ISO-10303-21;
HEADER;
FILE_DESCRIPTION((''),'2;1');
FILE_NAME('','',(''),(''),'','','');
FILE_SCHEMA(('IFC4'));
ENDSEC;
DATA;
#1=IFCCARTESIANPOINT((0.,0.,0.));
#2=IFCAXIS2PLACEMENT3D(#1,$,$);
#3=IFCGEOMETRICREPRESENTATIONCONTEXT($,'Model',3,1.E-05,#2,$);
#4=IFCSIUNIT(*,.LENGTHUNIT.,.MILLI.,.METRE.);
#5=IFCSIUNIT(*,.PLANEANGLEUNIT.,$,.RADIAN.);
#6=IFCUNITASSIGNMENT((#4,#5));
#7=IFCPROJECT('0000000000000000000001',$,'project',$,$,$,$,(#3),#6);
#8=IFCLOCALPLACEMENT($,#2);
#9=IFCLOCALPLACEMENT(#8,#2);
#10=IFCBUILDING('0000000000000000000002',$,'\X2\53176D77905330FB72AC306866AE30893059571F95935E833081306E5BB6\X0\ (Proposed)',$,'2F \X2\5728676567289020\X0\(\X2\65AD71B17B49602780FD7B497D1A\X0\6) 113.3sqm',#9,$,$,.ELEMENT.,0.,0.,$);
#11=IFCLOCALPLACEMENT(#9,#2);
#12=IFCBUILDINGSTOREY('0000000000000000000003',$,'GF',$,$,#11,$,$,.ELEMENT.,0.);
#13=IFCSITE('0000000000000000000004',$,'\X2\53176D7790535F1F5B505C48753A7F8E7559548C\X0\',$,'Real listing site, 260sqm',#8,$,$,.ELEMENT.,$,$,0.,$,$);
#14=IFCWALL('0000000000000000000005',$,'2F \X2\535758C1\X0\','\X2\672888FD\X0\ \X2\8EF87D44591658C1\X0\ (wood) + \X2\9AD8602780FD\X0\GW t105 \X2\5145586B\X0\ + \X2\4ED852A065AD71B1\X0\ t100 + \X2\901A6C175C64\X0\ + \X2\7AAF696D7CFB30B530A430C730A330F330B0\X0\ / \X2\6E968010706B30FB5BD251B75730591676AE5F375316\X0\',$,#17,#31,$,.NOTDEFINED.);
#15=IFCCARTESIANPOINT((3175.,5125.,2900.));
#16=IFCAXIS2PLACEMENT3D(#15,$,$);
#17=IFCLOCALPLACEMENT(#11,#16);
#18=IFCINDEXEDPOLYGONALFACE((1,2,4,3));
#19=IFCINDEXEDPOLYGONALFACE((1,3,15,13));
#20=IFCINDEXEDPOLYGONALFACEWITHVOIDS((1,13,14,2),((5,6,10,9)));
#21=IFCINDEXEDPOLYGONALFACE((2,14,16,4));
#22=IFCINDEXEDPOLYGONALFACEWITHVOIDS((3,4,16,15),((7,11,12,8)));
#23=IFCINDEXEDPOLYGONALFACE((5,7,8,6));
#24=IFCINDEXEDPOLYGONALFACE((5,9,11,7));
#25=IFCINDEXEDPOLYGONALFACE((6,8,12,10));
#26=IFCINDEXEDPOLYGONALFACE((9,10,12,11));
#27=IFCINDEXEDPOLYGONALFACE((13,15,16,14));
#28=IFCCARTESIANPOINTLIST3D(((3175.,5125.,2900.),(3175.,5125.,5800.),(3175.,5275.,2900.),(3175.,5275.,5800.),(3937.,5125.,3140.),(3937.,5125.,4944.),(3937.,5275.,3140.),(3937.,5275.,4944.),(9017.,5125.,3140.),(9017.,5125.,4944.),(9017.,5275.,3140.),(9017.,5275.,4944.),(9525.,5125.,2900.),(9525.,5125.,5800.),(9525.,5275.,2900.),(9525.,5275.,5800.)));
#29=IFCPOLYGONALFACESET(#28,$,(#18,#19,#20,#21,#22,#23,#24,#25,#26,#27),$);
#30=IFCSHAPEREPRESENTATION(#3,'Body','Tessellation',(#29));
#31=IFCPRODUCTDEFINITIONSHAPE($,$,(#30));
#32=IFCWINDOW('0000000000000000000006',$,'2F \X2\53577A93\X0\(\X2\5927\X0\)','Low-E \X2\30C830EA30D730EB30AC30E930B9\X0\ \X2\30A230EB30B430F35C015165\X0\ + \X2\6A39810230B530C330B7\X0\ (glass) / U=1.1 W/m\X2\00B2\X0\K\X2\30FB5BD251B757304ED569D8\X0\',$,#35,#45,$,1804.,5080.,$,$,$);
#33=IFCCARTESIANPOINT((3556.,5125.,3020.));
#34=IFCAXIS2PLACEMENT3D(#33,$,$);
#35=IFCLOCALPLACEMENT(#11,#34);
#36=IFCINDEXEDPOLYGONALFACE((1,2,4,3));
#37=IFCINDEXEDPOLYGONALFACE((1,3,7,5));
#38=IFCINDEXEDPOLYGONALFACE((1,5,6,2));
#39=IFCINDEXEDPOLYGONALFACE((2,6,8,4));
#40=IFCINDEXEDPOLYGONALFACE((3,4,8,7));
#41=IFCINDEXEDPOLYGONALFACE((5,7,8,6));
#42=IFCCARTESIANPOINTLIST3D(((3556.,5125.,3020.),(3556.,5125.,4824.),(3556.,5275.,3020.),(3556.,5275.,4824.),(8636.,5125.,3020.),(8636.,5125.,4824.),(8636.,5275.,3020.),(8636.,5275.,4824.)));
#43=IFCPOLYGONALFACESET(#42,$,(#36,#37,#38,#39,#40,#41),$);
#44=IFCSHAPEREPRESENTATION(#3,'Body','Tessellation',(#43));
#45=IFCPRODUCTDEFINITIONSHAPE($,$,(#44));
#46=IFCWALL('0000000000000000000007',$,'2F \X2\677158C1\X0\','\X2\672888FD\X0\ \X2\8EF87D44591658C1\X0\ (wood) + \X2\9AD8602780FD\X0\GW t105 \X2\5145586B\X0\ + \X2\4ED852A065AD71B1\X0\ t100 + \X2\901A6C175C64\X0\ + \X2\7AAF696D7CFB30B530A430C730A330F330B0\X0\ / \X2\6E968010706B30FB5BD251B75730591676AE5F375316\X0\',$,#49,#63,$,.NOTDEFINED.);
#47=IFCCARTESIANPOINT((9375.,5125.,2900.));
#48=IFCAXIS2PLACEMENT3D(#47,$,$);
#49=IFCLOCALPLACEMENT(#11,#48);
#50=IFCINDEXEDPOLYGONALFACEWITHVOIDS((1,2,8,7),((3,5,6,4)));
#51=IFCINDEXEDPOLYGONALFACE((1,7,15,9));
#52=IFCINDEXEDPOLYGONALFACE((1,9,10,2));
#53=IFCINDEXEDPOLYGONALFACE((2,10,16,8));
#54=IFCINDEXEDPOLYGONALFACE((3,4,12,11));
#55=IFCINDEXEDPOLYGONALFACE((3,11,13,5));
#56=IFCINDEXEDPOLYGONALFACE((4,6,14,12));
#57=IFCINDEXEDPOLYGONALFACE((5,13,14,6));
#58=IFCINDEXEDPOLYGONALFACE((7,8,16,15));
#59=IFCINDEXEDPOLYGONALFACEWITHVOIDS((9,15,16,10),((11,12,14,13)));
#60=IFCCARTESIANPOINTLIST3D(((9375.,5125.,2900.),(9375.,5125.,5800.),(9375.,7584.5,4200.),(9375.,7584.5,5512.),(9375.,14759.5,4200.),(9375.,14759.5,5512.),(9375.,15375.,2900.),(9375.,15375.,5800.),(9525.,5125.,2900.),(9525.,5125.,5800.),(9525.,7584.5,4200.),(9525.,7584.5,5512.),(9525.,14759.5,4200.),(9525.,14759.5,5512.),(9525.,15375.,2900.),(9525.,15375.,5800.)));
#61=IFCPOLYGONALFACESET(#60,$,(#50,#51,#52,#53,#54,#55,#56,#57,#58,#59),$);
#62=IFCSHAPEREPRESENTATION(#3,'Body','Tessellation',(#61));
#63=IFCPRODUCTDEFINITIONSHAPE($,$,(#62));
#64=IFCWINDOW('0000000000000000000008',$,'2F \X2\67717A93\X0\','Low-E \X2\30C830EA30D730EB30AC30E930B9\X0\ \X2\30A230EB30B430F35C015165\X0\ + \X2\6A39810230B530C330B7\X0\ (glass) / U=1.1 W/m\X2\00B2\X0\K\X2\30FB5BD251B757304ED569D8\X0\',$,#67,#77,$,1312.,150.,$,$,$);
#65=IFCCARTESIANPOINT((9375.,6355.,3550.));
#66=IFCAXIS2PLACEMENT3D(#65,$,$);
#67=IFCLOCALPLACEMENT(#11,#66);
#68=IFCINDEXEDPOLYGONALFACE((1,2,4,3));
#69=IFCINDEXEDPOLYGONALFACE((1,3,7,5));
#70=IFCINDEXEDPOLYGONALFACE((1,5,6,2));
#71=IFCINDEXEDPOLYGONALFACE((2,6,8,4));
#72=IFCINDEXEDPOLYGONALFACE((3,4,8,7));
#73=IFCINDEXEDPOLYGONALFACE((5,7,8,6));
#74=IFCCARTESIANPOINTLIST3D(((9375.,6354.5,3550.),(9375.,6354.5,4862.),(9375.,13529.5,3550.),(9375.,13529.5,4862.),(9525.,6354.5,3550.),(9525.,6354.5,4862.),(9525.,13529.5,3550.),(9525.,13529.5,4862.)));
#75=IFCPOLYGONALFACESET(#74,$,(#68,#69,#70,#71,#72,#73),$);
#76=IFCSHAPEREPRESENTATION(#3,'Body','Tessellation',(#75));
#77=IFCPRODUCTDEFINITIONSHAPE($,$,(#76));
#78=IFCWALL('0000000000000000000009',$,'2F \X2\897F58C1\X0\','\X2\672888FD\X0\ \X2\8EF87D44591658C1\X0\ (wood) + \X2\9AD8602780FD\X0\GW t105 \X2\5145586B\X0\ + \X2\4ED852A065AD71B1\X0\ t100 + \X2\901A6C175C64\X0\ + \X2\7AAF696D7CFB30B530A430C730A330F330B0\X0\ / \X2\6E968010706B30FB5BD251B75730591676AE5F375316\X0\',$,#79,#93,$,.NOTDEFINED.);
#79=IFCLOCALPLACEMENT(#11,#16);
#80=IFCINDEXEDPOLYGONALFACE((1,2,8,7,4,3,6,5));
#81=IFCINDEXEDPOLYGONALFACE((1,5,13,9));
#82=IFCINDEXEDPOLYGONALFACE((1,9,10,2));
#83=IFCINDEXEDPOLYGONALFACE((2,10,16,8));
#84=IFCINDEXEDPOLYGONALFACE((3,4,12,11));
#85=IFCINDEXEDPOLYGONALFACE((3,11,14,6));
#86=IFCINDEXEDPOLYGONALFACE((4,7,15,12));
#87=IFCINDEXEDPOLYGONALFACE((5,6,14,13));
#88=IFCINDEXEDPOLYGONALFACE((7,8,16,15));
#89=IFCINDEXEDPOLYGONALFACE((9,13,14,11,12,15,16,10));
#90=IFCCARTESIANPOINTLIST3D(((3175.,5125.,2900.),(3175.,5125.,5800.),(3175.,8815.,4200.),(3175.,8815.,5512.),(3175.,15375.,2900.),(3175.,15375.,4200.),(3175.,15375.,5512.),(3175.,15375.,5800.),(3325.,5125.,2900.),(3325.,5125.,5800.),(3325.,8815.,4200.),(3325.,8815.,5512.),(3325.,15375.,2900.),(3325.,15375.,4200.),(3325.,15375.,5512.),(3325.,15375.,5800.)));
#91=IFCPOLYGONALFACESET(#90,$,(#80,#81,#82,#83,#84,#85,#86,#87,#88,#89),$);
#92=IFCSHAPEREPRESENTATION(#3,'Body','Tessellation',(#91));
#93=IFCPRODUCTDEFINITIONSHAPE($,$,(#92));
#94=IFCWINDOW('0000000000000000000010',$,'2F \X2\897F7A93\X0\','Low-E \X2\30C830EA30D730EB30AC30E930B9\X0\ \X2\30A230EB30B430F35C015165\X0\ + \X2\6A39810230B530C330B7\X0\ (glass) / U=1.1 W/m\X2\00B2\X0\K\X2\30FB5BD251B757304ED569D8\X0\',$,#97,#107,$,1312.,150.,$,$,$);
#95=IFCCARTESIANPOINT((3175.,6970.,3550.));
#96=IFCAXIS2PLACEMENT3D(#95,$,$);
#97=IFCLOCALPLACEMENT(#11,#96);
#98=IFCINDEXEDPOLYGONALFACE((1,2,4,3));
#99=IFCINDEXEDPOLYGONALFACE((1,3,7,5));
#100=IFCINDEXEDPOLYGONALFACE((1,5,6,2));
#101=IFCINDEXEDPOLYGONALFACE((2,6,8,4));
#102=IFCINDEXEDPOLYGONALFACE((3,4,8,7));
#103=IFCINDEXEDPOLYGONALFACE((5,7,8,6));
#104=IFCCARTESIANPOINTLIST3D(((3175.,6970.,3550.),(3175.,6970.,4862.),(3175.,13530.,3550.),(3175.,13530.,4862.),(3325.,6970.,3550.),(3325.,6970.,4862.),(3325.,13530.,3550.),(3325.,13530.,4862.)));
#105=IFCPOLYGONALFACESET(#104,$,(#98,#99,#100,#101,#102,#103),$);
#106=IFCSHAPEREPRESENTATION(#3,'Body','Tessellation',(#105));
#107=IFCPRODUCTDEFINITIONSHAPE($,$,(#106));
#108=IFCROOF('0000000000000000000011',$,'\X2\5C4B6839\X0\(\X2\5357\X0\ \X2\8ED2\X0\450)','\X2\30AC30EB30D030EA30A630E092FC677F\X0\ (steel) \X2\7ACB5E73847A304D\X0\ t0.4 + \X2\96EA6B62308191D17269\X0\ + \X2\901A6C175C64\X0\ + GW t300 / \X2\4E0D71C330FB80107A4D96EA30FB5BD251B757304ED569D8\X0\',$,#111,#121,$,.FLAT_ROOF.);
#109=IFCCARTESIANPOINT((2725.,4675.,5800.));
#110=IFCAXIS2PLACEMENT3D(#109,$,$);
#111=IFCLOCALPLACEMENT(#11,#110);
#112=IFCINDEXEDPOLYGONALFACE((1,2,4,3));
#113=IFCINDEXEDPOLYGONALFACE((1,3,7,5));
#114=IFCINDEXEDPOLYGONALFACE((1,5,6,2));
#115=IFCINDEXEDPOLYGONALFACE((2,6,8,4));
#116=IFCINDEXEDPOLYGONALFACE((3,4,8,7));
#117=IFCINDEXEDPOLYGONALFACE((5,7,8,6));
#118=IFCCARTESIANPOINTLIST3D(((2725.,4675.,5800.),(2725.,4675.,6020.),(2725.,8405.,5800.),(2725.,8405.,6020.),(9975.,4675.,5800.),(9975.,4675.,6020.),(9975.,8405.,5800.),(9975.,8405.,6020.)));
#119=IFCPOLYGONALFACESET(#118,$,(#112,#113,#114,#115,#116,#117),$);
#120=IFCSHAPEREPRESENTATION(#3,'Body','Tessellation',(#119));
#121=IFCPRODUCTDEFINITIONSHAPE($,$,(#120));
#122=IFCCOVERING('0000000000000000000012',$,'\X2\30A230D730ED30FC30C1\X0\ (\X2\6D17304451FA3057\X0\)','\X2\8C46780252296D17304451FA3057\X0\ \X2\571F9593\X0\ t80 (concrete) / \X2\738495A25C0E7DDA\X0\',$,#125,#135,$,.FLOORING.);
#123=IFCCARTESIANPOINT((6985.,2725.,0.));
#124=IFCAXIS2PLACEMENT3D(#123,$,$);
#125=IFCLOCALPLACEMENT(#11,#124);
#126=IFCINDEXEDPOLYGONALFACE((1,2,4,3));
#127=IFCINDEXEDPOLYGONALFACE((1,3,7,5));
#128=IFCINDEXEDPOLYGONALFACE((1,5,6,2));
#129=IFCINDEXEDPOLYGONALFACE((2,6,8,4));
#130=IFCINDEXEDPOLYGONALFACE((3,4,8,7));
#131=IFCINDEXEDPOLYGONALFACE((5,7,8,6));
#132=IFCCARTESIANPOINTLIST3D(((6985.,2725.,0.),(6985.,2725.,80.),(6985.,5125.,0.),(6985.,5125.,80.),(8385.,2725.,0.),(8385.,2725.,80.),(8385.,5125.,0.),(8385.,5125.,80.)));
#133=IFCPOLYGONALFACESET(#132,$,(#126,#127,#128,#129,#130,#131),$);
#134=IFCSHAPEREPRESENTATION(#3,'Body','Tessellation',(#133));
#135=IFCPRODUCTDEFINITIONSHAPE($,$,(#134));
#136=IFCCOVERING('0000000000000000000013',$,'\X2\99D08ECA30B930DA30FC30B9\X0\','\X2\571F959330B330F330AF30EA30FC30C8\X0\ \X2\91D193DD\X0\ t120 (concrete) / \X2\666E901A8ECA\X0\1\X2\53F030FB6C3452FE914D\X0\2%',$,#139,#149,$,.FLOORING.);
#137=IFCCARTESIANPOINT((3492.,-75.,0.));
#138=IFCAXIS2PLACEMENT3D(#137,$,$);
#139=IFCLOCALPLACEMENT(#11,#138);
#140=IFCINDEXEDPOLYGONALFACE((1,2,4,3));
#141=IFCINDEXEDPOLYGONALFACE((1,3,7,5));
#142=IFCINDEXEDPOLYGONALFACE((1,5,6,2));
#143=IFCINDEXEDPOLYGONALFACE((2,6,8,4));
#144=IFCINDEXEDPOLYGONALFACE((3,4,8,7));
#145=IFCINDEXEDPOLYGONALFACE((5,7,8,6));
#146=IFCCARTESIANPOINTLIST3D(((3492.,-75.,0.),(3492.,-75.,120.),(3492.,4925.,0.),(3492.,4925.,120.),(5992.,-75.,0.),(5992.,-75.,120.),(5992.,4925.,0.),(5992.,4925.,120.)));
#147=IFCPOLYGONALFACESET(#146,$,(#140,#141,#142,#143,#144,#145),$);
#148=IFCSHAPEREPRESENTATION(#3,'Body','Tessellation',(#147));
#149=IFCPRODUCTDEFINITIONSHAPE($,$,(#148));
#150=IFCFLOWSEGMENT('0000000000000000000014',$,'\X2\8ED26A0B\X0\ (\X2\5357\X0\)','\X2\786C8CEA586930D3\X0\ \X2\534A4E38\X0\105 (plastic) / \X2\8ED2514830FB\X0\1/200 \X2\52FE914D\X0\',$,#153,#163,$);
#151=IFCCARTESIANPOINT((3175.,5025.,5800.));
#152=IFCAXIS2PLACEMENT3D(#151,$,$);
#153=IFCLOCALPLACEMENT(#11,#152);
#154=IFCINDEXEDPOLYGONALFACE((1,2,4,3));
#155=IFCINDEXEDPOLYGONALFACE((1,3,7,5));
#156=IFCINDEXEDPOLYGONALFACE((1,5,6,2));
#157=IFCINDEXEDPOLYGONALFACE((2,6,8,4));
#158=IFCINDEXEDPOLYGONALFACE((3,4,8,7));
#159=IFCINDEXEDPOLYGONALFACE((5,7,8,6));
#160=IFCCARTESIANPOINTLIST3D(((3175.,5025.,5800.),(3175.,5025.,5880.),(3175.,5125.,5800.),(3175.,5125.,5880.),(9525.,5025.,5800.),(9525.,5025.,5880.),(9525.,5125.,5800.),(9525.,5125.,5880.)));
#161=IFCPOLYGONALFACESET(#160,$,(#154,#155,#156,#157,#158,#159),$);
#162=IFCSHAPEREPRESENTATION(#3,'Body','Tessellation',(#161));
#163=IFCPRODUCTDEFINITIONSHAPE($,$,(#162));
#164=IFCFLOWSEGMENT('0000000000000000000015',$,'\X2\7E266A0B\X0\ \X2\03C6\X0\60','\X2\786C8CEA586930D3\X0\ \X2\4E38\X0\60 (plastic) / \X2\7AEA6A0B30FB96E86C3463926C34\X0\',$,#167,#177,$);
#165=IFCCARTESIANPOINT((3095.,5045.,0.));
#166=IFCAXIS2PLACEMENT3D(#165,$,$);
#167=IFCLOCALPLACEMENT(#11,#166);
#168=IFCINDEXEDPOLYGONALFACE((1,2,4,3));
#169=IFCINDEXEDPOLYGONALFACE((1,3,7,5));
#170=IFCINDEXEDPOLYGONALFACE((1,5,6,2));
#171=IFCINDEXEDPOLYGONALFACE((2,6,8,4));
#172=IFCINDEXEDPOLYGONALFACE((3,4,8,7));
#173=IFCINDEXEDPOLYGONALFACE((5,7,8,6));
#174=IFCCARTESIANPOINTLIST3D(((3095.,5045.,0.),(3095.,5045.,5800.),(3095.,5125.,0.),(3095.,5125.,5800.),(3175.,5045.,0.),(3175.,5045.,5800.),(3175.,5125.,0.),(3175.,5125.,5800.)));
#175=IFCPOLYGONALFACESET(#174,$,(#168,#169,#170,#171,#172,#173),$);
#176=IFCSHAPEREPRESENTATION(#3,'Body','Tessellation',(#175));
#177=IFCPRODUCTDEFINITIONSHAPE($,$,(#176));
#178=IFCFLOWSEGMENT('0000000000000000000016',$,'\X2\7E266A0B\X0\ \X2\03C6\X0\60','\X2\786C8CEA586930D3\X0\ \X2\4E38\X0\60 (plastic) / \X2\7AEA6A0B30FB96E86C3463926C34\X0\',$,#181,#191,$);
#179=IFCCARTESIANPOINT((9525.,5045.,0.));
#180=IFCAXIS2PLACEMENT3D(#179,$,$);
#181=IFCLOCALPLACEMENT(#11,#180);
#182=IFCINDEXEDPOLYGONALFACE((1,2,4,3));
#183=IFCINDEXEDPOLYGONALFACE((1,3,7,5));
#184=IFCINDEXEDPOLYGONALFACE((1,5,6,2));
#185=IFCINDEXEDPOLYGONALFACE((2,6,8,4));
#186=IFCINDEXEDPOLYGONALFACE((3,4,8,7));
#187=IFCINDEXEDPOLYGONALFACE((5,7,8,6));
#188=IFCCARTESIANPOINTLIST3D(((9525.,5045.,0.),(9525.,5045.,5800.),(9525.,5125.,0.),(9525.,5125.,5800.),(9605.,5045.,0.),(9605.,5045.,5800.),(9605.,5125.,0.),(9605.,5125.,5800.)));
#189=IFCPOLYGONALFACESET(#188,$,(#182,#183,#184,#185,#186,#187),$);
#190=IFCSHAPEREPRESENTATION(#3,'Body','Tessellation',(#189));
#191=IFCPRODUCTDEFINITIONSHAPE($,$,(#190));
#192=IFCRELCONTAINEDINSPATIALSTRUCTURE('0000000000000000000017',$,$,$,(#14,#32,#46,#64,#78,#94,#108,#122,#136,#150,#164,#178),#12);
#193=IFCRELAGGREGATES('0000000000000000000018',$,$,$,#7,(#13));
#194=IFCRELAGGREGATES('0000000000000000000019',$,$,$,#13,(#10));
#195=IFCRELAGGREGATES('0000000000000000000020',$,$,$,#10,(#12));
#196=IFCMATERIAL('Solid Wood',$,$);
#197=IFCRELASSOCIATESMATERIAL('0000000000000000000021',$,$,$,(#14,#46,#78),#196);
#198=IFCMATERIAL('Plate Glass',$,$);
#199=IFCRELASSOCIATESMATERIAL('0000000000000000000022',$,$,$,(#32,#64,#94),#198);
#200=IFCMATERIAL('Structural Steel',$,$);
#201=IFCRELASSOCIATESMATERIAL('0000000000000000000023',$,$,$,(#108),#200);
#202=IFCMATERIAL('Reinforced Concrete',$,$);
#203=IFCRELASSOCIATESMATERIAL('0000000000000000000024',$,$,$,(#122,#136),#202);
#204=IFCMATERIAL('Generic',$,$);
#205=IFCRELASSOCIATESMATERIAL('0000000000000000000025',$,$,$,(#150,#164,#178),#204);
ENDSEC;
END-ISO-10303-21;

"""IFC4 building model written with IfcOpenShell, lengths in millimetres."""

from ifc_helpers import new_model, si_unit, frame, frame_2d, origin, place, context, project, spatial, rectangle, extrude, material, element, fill, save


model = new_model("IFC4")

# Units and contexts
model_context = context("Model", 3, precision=1e-05, world=origin())
ifc_project = project(units=[si_unit("LENGTHUNIT", "METRE", prefix="MILLI"), si_unit("PLANEANGLEUNIT", "RADIAN")], contexts=[model_context])

# Site, building, storey
site_placement = place(None, origin())
site = spatial("IfcSite", under=ifc_project, at=site_placement, Name="北海道弟子屈町美留和", ObjectType="Real listing site, 260sqm", CompositionType="ELEMENT", RefElevation=0.0)
building_placement = place(site_placement, origin())
building = spatial("IfcBuilding", under=site, at=building_placement, Name="北海道・犬と暮らす土間広めの家 (Proposed)", ObjectType="2F 在来木造(断熱等性能等級6) 113.3sqm", CompositionType="ELEMENT", ElevationOfRefHeight=0.0, ElevationOfTerrain=0.0)
storey_placement = place(building_placement, origin())
storey = spatial("IfcBuildingStorey", under=building, at=storey_placement, Name="GF", CompositionType="ELEMENT", Elevation=0.0)

# Shared definitions
ifc_material_1 = material(Name="Solid Wood")

# Shared definitions
ifc_material_2 = material(Name="Reinforced Concrete")

# Shared definitions
ifc_material_3 = material(Name="Plate Glass")

# Walls, openings, windows
wall_1_placement = place(storey_placement, frame((3175.0, 5125.0, 2900.0)))
wall_1 = element("IfcWall", 1, at=wall_1_placement, inside=storey, material=ifc_material_1, Name="2F 南壁", Description="木製 軸組外壁 (wood) + 高性能GW t105 充填 + 付加断熱 t100 + 通気層 + 窯業系サイディング / 準耐火・寒冷地外皮強化", PredefinedType="NOTDEFINED", context=model_context, shape_type="SweptSolid", body=[
    extrude(rectangle(XDim=6350.0, YDim=150.0, at=frame_2d((3175.0, 75.0))), frame((3175.0, 5125.0, 2900.0)), (0.0, 0.0, 1.0), 2900.0),
])
opening_1_placement = place(storey_placement, frame((3556.0, 5125.0, 3020.0)))
opening_1 = element("IfcOpeningElement", 2, at=opening_1_placement, cuts=wall_1, PredefinedType="NOTDEFINED", context=model_context, shape_type="SweptSolid", body=[
    extrude(rectangle(XDim=5080.0, YDim=150.0, at=frame_2d((2540.0, 75.0))), frame((3556.0, 5125.0, 3020.0)), (0.0, 0.0, 1.0), 1804.0),
])
window_1_placement = place(storey_placement, frame((3556.0, 5125.0, 3020.0)))
window_1 = element("IfcWindow", 3, at=window_1_placement, inside=storey, material=ifc_material_3, Name="2F 南窓(大)", Description="Low-E トリプルガラス アルゴン封入 + 樹脂サッシ (glass) / U=1.1 W/m²K・寒冷地仕様", OverallHeight=1804.0, OverallWidth=5080.0, context=model_context, shape_type="SweptSolid", body=[
    extrude(rectangle(XDim=5080.0, YDim=150.0, at=frame_2d((2540.0, 75.0))), frame((3556.0, 5125.0, 3020.0)), (0.0, 0.0, 1.0), 1804.0),
])
fill(opening_1, window_1)
wall_2_placement = place(storey_placement, frame((9375.0, 5125.0, 2900.0)))
wall_2 = element("IfcWall", 4, at=wall_2_placement, inside=storey, material=ifc_material_1, Name="2F 東壁", Description="木製 軸組外壁 (wood) + 高性能GW t105 充填 + 付加断熱 t100 + 通気層 + 窯業系サイディング / 準耐火・寒冷地外皮強化", PredefinedType="NOTDEFINED", context=model_context, shape_type="SweptSolid", body=[
    extrude(rectangle(XDim=150.0, YDim=10250.0, at=frame_2d((75.0, 5125.0))), frame((9375.0, 5125.0, 2900.0)), (0.0, 0.0, 1.0), 2900.0),
])
opening_2_placement = place(storey_placement, frame((9375.0, 6355.0, 3550.0)))
opening_2 = element("IfcOpeningElement", 5, at=opening_2_placement, cuts=wall_2, PredefinedType="NOTDEFINED", context=model_context, shape_type="SweptSolid", body=[
    extrude(rectangle(XDim=150.0, YDim=7175.0, at=frame_2d((75.0, 3587.0))), frame((9375.0, 6355.0, 3550.0)), (0.0, 0.0, 1.0), 1312.0),
])
window_2_placement = place(storey_placement, frame((9375.0, 6355.0, 3550.0)))
window_2 = element("IfcWindow", 6, at=window_2_placement, inside=storey, material=ifc_material_3, Name="2F 東窓", Description="Low-E トリプルガラス アルゴン封入 + 樹脂サッシ (glass) / U=1.1 W/m²K・寒冷地仕様", OverallHeight=1312.0, OverallWidth=150.0, context=model_context, shape_type="SweptSolid", body=[
    extrude(rectangle(XDim=150.0, YDim=7175.0, at=frame_2d((75.0, 3587.0))), frame((9375.0, 6355.0, 3550.0)), (0.0, 0.0, 1.0), 1312.0),
])
fill(opening_2, window_2)
wall_3_placement = place(storey_placement, frame((3175.0, 5125.0, 2900.0)))
wall_3 = element("IfcWall", 7, at=wall_3_placement, inside=storey, material=ifc_material_1, Name="2F 西壁", Description="木製 軸組外壁 (wood) + 高性能GW t105 充填 + 付加断熱 t100 + 通気層 + 窯業系サイディング / 準耐火・寒冷地外皮強化", PredefinedType="NOTDEFINED", context=model_context, shape_type="SweptSolid", body=[
    extrude(rectangle(XDim=150.0, YDim=10250.0, at=frame_2d((75.0, 5125.0))), frame((3175.0, 5125.0, 2900.0)), (0.0, 0.0, 1.0), 2900.0),
])
opening_3_placement = place(storey_placement, frame((3175.0, 6970.0, 3550.0)))
opening_3 = element("IfcOpeningElement", 8, at=opening_3_placement, cuts=wall_3, PredefinedType="NOTDEFINED", context=model_context, shape_type="SweptSolid", body=[
    extrude(rectangle(XDim=150.0, YDim=6560.0, at=frame_2d((75.0, 3280.0))), frame((3175.0, 6970.0, 3550.0)), (0.0, 0.0, 1.0), 1312.0),
])
window_3_placement = place(storey_placement, frame((3175.0, 6970.0, 3550.0)))
window_3 = element("IfcWindow", 9, at=window_3_placement, inside=storey, material=ifc_material_3, Name="2F 西窓", Description="Low-E トリプルガラス アルゴン封入 + 樹脂サッシ (glass) / U=1.1 W/m²K・寒冷地仕様", OverallHeight=1312.0, OverallWidth=150.0, context=model_context, shape_type="SweptSolid", body=[
    extrude(rectangle(XDim=150.0, YDim=6560.0, at=frame_2d((75.0, 3280.0))), frame((3175.0, 6970.0, 3550.0)), (0.0, 0.0, 1.0), 1312.0),
])
fill(opening_3, window_3)

# Roof
ifc_material_4 = material(Name="Structural Steel")
for number, where, name in (
    (10, (2725.0, 4675.0, 5800.0), "屋根(南 軒450)"),
):
    element("IfcRoof", number, at=place(storey_placement, frame(where)), inside=storey, material=ifc_material_4, Name=name, Description="ガルバリウム鋼板 (steel) 立平葺き t0.4 + 雪止め金物 + 通気層 + GW t300 / 不燃・耐積雪・寒冷地仕様", PredefinedType="FLAT_ROOF", context=model_context, shape_type="SweptSolid", body=[
        extrude(rectangle(XDim=7250.0, YDim=3730.0, at=frame_2d((3625.0, 1865.0))), frame((2725.0, 4675.0, 5800.0)), (0.0, 0.0, 1.0), 220.0),
    ])

# Coverings
covering_1_placement = place(storey_placement, frame((6985.0, 2725.0, 0.0)))
element("IfcCovering", 11, at=covering_1_placement, inside=storey, material=ifc_material_2, Name="アプローチ (洗い出し)", Description="豆砂利洗い出し 土間 t80 (concrete) / 玄関導線", PredefinedType="FLOORING", context=model_context, shape_type="SweptSolid", body=[
    extrude(rectangle(XDim=1400.0, YDim=2400.0, at=frame_2d((700.0, 1200.0))), frame((6985.0, 2725.0, 0.0)), (0.0, 0.0, 1.0), 80.0),
])
covering_2_placement = place(storey_placement, frame((3492.0, -75.0, 0.0)))
element("IfcCovering", 12, at=covering_2_placement, inside=storey, material=ifc_material_2, Name="駐車スペース", Description="土間コンクリート 金鏝 t120 (concrete) / 普通車1台・水勾配2%", PredefinedType="FLOORING", context=model_context, shape_type="SweptSolid", body=[
    extrude(rectangle(XDim=2500.0, YDim=5000.0, at=frame_2d((1250.0, 2500.0))), frame((3492.0, -75.0, 0.0)), (0.0, 0.0, 1.0), 120.0),
])

# Flow segments
ifc_material_5 = material(Name="Generic")
flow_segment_1_placement = place(storey_placement, frame((3175.0, 5025.0, 5800.0)))
element("IfcFlowSegment", 13, at=flow_segment_1_placement, inside=storey, material=ifc_material_5, Name="軒樋 (南)", Description="硬質塩ビ 半丸105 (plastic) / 軒先・1/200 勾配", context=model_context, shape_type="SweptSolid", body=[
    extrude(rectangle(XDim=6350.0, YDim=100.0, at=frame_2d((3175.0, 50.0))), frame((3175.0, 5025.0, 5800.0)), (0.0, 0.0, 1.0), 80.0),
])
flow_segment_2_placement = place(storey_placement, frame((3095.0, 5045.0, 0.0)))
element("IfcFlowSegment", 14, at=flow_segment_2_placement, inside=storey, material=ifc_material_5, Name="縦樋 φ60", Description="硬質塩ビ 丸60 (plastic) / 竪樋・雨水排水", context=model_context, shape_type="SweptSolid", body=[
    extrude(rectangle(XDim=80.0, YDim=80.0, at=frame_2d((40.0, 40.0))), frame((3095.0, 5045.0, 0.0)), (0.0, 0.0, 1.0), 5800.0),
])
flow_segment_3_placement = place(storey_placement, frame((9525.0, 5045.0, 0.0)))
element("IfcFlowSegment", 15, at=flow_segment_3_placement, inside=storey, material=ifc_material_5, Name="縦樋 φ60", Description="硬質塩ビ 丸60 (plastic) / 竪樋・雨水排水", context=model_context, shape_type="SweptSolid", body=[
    extrude(rectangle(XDim=80.0, YDim=80.0, at=frame_2d((40.0, 40.0))), frame((9525.0, 5045.0, 0.0)), (0.0, 0.0, 1.0), 5800.0),
])

save(model, "model.ifc")
